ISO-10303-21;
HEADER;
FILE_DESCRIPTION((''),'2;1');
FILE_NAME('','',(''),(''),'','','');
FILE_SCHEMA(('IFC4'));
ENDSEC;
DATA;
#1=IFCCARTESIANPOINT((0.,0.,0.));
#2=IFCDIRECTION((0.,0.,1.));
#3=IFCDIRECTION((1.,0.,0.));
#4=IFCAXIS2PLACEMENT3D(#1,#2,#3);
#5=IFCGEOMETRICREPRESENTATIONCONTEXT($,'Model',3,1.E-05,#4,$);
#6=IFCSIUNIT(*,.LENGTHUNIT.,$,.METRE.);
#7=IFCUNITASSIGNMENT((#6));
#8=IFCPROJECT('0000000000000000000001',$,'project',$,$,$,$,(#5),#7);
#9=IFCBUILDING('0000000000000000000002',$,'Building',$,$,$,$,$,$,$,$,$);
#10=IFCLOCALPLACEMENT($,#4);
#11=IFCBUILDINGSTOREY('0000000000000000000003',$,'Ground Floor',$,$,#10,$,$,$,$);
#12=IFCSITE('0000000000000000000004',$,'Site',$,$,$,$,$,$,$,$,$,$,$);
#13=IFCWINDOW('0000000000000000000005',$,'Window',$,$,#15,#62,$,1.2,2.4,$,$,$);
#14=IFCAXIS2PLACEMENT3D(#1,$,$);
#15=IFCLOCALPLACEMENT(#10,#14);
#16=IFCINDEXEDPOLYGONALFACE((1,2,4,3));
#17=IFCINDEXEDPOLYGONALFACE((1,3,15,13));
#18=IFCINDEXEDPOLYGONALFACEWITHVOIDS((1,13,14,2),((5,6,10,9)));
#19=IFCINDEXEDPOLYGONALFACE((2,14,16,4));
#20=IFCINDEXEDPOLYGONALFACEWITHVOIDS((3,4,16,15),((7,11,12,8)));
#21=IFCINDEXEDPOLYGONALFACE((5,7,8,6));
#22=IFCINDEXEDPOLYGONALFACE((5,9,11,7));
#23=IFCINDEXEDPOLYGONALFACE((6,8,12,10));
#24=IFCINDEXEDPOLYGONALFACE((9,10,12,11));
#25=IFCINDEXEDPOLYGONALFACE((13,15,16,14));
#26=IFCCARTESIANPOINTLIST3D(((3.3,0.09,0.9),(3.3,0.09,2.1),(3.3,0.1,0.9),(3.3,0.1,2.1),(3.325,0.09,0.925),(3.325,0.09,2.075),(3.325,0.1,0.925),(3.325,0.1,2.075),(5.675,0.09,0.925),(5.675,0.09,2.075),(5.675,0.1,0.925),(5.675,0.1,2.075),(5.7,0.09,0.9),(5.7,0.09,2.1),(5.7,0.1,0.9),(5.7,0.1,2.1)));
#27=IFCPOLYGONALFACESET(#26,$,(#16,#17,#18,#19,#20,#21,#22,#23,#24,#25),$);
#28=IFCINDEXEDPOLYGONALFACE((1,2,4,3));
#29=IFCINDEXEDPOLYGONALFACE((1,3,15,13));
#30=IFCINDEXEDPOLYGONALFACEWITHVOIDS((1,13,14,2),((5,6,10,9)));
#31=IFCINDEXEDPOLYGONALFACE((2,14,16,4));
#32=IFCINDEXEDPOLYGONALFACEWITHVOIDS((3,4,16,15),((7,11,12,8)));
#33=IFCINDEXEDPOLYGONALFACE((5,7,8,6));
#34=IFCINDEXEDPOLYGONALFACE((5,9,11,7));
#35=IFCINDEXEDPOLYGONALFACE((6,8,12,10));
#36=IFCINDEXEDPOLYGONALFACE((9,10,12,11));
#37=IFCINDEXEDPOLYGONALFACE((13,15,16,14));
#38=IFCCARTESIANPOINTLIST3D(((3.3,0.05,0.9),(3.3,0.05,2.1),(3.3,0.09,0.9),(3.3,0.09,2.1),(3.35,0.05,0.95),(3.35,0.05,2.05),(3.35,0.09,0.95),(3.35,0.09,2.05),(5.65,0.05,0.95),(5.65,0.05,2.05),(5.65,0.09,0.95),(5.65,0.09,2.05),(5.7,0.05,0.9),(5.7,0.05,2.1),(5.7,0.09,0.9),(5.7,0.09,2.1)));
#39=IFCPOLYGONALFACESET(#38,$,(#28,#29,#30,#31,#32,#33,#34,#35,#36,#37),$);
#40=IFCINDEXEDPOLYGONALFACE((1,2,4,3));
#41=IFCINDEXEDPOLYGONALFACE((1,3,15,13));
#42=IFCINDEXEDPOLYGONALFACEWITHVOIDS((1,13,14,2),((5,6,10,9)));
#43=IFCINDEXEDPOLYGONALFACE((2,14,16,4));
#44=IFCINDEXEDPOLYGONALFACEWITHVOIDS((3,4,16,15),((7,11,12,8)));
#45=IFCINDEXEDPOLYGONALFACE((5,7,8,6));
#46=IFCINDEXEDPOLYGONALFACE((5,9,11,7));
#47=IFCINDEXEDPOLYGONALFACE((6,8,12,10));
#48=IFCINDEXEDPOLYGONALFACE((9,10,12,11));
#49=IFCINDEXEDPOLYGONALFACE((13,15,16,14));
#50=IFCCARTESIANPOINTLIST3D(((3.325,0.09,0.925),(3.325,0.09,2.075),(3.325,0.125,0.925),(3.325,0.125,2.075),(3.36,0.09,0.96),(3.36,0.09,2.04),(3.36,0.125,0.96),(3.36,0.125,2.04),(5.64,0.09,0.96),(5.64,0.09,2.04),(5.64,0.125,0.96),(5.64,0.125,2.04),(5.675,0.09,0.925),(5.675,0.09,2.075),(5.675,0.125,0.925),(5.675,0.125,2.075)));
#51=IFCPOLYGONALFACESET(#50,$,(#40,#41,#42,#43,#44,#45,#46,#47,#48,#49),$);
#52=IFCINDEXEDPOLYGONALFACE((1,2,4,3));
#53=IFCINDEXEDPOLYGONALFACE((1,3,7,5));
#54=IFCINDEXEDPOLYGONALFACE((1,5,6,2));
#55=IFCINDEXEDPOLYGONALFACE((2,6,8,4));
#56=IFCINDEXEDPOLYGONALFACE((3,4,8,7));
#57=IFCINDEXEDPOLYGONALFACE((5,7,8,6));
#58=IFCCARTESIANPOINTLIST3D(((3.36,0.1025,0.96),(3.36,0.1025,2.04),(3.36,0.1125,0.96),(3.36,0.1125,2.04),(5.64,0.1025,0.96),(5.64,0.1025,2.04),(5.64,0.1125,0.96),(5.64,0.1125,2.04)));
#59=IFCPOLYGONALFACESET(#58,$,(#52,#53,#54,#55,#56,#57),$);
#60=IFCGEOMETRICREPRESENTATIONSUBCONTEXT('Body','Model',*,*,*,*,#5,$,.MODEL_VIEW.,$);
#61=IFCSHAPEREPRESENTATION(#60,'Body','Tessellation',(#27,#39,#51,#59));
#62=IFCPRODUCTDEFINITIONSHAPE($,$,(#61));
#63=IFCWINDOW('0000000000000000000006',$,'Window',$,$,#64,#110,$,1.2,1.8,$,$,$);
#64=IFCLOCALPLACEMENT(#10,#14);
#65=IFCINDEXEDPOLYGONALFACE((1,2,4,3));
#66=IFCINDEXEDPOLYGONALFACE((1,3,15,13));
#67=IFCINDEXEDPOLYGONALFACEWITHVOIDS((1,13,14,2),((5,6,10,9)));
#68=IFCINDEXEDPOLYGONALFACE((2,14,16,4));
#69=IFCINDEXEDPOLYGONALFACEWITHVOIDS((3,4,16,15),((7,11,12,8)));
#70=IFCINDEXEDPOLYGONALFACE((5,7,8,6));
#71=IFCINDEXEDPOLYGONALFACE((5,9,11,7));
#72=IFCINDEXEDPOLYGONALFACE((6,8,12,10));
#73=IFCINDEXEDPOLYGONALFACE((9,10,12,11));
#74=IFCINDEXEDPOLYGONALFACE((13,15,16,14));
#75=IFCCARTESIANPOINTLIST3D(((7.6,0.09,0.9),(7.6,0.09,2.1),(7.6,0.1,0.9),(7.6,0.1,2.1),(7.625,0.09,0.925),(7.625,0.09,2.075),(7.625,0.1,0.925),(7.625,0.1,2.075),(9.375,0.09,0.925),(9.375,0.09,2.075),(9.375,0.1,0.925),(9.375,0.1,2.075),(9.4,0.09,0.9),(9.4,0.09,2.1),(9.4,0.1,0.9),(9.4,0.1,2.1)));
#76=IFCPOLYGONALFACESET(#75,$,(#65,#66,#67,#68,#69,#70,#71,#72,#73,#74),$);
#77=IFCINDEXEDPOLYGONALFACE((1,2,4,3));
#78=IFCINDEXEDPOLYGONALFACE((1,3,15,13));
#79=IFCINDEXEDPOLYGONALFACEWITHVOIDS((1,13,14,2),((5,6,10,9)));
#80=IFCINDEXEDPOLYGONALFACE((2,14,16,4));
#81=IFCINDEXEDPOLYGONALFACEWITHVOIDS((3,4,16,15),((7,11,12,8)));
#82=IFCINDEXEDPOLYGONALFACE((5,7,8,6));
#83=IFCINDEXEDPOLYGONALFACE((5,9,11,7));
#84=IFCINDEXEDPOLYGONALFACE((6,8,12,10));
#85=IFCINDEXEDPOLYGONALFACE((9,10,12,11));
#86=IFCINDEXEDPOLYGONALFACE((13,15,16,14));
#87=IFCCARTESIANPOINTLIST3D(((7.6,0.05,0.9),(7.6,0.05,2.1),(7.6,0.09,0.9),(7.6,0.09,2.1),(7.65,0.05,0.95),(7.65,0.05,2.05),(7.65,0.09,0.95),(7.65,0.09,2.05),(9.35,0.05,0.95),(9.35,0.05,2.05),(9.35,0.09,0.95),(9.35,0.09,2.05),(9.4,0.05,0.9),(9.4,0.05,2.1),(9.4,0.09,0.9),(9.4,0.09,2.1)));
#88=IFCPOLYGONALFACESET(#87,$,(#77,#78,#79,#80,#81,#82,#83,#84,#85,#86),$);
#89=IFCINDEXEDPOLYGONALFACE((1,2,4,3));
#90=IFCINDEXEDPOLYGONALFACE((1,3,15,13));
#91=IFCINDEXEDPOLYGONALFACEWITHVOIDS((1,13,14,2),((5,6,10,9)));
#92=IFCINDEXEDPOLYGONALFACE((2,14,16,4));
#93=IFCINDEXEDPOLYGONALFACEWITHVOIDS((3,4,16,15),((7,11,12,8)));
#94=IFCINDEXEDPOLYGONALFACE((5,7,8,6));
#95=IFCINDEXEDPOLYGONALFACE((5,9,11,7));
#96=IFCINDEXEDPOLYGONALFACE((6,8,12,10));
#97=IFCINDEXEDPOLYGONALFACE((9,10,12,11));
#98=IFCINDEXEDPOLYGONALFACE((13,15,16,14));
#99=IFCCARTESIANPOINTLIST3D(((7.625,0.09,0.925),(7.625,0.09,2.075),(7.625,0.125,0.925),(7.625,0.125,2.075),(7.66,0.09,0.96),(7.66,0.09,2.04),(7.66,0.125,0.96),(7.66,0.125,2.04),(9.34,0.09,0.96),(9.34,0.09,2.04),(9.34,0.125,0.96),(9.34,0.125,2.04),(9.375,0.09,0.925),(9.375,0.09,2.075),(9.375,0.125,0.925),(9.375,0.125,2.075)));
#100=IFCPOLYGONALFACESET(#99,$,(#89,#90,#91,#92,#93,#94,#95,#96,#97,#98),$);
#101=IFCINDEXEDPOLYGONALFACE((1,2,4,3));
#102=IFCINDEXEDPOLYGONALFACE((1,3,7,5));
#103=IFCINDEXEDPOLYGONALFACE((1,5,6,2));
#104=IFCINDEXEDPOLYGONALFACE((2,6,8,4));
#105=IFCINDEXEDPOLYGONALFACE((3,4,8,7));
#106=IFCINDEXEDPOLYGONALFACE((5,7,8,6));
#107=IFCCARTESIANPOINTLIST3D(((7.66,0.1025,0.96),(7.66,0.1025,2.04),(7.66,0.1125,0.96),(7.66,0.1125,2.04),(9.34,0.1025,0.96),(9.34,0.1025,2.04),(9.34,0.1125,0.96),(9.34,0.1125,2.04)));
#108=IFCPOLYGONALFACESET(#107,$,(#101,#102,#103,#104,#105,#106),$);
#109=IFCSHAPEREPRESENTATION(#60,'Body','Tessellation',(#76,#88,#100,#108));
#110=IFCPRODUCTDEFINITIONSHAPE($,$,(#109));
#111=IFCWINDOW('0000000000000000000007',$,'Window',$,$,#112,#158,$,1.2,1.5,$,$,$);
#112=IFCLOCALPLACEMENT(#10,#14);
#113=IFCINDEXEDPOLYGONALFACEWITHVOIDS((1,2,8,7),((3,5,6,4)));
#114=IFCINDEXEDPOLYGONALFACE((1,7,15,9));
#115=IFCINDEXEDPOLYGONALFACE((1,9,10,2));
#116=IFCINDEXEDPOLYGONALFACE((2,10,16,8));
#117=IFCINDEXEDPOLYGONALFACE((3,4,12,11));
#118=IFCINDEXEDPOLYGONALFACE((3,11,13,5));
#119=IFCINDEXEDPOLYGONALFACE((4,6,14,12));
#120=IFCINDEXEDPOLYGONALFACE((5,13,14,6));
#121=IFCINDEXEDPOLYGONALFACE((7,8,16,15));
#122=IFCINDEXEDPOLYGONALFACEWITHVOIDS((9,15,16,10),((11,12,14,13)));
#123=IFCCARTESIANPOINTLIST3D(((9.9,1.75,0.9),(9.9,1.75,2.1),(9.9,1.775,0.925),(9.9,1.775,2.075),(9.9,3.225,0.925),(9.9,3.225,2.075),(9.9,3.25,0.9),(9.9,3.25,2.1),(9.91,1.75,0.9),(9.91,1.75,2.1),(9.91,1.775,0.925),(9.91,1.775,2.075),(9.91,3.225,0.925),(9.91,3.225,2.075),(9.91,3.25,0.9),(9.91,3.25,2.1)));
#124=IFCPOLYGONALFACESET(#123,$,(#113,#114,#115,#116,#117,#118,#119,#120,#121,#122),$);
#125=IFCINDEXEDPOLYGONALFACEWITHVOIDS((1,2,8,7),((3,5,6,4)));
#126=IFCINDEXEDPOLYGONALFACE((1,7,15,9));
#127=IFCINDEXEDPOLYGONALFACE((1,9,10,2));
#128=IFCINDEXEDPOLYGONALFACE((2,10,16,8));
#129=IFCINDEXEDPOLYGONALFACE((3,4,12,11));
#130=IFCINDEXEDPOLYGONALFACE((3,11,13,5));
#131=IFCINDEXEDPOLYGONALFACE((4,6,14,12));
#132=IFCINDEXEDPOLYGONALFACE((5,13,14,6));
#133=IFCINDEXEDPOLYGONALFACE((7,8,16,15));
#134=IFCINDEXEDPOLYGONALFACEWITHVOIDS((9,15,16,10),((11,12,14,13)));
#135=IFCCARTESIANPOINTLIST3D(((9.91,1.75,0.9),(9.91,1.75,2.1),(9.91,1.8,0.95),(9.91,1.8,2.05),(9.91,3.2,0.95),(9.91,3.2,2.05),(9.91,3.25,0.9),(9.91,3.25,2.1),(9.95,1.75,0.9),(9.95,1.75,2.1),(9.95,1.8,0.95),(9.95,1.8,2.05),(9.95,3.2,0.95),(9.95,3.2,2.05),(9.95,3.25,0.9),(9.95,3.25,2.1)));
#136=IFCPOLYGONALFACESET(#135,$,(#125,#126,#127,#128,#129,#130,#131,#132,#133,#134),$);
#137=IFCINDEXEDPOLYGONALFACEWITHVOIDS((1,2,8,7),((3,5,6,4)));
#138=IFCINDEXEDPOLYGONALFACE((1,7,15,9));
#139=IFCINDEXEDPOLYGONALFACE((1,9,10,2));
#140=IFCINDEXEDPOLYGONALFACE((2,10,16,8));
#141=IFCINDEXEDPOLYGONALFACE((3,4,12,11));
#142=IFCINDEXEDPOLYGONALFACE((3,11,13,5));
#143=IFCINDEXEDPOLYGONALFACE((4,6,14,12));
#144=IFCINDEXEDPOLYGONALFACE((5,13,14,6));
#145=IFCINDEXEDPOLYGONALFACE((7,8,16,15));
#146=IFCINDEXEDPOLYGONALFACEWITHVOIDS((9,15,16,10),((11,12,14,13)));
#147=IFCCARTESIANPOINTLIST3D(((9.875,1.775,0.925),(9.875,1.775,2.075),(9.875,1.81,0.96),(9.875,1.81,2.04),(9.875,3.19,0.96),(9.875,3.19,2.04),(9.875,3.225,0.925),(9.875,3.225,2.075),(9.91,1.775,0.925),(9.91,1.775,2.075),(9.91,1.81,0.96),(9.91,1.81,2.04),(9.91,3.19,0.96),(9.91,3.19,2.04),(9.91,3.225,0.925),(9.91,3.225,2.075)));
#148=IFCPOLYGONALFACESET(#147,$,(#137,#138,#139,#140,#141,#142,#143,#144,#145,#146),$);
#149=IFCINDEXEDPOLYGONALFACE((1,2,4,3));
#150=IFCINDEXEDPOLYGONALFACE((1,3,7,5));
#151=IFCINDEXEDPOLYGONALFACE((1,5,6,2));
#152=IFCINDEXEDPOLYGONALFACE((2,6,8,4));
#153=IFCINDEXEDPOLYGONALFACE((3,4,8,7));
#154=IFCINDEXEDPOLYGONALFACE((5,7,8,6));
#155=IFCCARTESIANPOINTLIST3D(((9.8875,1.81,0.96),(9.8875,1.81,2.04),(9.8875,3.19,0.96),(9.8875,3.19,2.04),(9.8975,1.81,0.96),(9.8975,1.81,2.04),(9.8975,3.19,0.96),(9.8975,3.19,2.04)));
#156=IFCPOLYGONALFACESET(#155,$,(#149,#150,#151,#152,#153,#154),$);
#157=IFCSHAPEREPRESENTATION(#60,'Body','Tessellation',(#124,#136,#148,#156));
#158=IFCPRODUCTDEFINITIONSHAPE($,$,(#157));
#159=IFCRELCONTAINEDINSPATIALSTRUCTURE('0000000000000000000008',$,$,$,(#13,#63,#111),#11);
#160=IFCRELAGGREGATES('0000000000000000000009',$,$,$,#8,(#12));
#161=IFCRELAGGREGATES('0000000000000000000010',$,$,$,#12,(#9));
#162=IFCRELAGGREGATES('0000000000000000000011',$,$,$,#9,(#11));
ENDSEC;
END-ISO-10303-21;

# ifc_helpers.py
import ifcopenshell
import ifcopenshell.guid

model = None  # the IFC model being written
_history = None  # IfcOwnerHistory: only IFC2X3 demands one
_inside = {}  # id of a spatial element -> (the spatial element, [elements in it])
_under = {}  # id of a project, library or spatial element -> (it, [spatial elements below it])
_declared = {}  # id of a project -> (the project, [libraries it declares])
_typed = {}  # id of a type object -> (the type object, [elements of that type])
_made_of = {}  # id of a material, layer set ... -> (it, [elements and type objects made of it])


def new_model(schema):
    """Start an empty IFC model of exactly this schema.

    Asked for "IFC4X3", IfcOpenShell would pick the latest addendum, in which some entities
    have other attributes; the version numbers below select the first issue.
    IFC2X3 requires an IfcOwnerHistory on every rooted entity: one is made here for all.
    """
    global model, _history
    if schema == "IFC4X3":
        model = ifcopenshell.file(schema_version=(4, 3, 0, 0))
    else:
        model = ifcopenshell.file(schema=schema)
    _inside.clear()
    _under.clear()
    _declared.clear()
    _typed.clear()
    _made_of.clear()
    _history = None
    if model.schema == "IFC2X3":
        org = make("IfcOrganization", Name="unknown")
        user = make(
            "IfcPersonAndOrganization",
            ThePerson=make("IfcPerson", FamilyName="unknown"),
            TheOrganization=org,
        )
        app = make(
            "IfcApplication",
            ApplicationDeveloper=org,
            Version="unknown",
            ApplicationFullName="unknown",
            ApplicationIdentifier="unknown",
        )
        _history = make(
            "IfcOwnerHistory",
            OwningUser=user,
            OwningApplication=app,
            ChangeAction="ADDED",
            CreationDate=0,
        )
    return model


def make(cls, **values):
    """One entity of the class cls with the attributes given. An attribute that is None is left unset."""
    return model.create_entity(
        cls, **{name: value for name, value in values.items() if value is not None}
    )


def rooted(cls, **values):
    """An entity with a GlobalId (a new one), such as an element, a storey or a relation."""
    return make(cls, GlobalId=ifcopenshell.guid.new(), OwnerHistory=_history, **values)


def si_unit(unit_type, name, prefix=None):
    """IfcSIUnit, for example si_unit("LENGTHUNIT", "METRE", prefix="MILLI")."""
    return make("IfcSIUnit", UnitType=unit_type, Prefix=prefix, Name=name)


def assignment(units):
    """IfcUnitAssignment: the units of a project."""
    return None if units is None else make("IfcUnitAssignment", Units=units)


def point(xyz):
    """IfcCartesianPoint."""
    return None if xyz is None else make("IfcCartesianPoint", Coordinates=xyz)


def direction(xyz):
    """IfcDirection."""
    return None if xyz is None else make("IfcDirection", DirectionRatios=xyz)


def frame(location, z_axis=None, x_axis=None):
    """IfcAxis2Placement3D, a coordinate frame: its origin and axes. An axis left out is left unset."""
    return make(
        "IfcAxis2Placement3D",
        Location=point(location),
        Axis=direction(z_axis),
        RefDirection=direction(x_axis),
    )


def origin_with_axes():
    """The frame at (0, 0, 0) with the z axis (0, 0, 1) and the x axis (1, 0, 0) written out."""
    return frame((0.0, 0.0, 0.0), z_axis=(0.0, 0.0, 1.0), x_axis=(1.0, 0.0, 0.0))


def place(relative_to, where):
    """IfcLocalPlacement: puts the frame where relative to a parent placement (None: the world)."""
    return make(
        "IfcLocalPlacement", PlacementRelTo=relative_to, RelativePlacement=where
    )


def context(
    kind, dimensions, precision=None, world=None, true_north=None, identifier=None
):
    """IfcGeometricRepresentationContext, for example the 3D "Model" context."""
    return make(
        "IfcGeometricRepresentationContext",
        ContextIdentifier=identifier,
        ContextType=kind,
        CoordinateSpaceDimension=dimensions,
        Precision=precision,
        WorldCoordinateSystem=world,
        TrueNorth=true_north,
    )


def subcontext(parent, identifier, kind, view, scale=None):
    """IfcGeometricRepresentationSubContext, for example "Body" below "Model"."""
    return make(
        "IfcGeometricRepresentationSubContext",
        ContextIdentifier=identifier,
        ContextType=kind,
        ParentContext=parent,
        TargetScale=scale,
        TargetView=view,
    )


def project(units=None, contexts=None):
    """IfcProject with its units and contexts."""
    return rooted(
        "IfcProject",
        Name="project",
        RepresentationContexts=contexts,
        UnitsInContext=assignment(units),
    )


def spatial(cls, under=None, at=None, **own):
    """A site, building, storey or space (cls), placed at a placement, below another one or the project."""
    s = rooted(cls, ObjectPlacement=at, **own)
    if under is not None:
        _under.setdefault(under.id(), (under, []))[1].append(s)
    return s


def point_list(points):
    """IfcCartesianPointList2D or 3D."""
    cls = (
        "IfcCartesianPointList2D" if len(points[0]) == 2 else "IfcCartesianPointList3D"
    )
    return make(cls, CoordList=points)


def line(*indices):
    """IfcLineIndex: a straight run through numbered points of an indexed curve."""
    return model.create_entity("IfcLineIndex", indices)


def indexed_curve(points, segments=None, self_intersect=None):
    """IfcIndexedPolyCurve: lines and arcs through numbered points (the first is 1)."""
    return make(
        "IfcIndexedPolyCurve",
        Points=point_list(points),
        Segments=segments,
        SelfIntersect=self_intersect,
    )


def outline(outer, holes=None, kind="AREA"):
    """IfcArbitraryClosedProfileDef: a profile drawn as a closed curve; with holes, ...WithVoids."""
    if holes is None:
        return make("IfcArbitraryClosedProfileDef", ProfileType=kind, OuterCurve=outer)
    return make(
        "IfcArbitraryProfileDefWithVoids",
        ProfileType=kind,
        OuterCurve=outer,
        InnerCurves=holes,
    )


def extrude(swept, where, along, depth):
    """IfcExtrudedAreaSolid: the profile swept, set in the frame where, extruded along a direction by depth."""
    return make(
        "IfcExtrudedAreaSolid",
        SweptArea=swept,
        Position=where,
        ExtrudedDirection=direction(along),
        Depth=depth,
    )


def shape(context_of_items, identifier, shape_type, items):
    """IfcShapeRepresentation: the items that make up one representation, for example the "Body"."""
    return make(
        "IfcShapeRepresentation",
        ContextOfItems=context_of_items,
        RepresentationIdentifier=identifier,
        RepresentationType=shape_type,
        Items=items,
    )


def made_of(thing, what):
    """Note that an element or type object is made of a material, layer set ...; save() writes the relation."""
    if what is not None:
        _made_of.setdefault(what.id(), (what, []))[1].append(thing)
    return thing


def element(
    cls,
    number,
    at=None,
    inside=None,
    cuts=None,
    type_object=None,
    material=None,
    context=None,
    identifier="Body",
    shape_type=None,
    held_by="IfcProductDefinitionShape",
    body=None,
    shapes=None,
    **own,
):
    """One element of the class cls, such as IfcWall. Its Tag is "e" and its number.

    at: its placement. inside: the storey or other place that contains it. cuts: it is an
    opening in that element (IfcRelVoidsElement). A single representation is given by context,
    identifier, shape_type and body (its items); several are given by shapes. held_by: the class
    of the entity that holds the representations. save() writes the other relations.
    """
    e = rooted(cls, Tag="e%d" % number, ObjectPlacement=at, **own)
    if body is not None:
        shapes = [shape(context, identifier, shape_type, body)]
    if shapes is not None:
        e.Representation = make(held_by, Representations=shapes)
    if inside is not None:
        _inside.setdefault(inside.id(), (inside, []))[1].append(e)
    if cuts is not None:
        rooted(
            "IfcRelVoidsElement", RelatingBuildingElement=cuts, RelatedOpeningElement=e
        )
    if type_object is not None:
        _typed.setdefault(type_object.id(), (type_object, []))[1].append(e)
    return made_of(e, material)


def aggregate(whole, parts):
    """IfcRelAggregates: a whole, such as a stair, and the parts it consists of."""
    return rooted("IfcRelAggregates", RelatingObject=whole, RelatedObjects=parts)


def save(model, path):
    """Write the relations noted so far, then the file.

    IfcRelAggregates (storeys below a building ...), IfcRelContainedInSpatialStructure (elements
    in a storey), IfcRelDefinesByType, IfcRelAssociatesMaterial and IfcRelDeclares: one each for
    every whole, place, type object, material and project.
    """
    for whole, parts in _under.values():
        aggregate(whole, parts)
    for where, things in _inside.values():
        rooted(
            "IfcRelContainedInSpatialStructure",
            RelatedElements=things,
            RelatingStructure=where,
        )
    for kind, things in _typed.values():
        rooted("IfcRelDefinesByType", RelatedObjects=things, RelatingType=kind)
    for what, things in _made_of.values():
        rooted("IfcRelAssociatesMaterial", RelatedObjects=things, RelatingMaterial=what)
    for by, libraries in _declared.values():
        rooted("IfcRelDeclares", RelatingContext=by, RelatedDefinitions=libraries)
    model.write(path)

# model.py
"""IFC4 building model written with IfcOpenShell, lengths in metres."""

from ifc_helpers import new_model, si_unit, frame, origin_with_axes, place, context, subcontext, project, spatial, line, indexed_curve, outline, extrude, element, save


model = new_model("IFC4")

# Units and contexts
model_context = context("Model", 3, precision=1e-05, world=origin_with_axes())
body_context = subcontext(model_context, "Body", "Model", "MODEL_VIEW")
ifc_project = project(units=[si_unit("LENGTHUNIT", "METRE")], contexts=[model_context])

# Site, building, storey
site = spatial("IfcSite", under=ifc_project, Name="Site")
building = spatial("IfcBuilding", under=site, Name="Building")
storey_placement = place(None, origin_with_axes())
storey = spatial("IfcBuildingStorey", under=building, at=storey_placement, Name="Ground Floor")

# Windows
window_1_placement = place(storey_placement, frame((3.3, 0.0, 0.9), z_axis=(0.0, 0.0, 1.0), x_axis=(1.0, 0.0, 0.0)))
element("IfcWindow", 1, at=window_1_placement, inside=storey, Name="Window", OverallHeight=1.2, OverallWidth=2.4, context=body_context, shape_type="SweptSolid", body=[
    extrude(outline(indexed_curve([(0.0, 0.0), (2.4, 0.0), (2.4, 1.2), (0.0, 1.2)], segments=[line(1, 2, 3, 4, 1)]), holes=[indexed_curve([(0.025, 0.025), (2.375, 0.025), (2.375, 1.175), (0.025, 1.175)], segments=[line(1, 2, 3, 4, 1)])]), frame((0.0, 0.09, 0.0), z_axis=(0.0, -1.0, 0.0), x_axis=(1.0, 0.0, 0.0)), (0.0, 0.0, -1.0), 0.01),
    extrude(outline(indexed_curve([(0.0, 0.0), (2.4, 0.0), (2.4, 1.2), (0.0, 1.2)], segments=[line(1, 2, 3, 4, 1)]), holes=[indexed_curve([(0.05, 0.05), (2.35, 0.05), (2.35, 1.15), (0.05, 1.15)], segments=[line(1, 2, 3, 4, 1)])]), frame((0.0, 0.05, 0.0), z_axis=(0.0, -1.0, 0.0), x_axis=(1.0, 0.0, 0.0)), (0.0, 0.0, -1.0), 0.04),
    extrude(outline(indexed_curve([(0.0, 0.0), (2.35, 0.0), (2.35, 1.15), (0.0, 1.15)], segments=[line(1, 2, 3, 4, 1)]), holes=[indexed_curve([(0.035, 0.035), (2.315, 0.035), (2.315, 1.115), (0.035, 1.115)], segments=[line(1, 2, 3, 4, 1)])]), frame((0.025, 0.09, 0.025), z_axis=(0.0, -1.0, 0.0), x_axis=(1.0, 0.0, 0.0)), (0.0, 0.0, -1.0), 0.035),
    extrude(outline(indexed_curve([(0.035, 0.035), (2.315, 0.035), (2.315, 1.115), (0.035, 1.115)], segments=[line(1, 2, 3, 4, 1)])), frame((0.025, 0.1025, 0.025), z_axis=(0.0, -1.0, 0.0), x_axis=(1.0, 0.0, 0.0)), (0.0, 0.0, -1.0), 0.01),
])
window_2_placement = place(storey_placement, frame((7.6, 0.0, 0.9), z_axis=(0.0, 0.0, 1.0), x_axis=(1.0, 0.0, 0.0)))
element("IfcWindow", 2, at=window_2_placement, inside=storey, Name="Window", OverallHeight=1.2, OverallWidth=1.8, context=body_context, shape_type="SweptSolid", body=[
    extrude(outline(indexed_curve([(0.0, 0.0), (1.8, 0.0), (1.8, 1.2), (0.0, 1.2)], segments=[line(1, 2, 3, 4, 1)]), holes=[indexed_curve([(0.025, 0.025), (1.775, 0.025), (1.775, 1.175), (0.025, 1.175)], segments=[line(1, 2, 3, 4, 1)])]), frame((0.0, 0.09, 0.0), z_axis=(0.0, -1.0, 0.0), x_axis=(1.0, 0.0, 0.0)), (0.0, 0.0, -1.0), 0.01),
    extrude(outline(indexed_curve([(0.0, 0.0), (1.8, 0.0), (1.8, 1.2), (0.0, 1.2)], segments=[line(1, 2, 3, 4, 1)]), holes=[indexed_curve([(0.05, 0.05), (1.75, 0.05), (1.75, 1.15), (0.05, 1.15)], segments=[line(1, 2, 3, 4, 1)])]), frame((0.0, 0.05, 0.0), z_axis=(0.0, -1.0, 0.0), x_axis=(1.0, 0.0, 0.0)), (0.0, 0.0, -1.0), 0.04),
    extrude(outline(indexed_curve([(0.0, 0.0), (1.75, 0.0), (1.75, 1.15), (0.0, 1.15)], segments=[line(1, 2, 3, 4, 1)]), holes=[indexed_curve([(0.035, 0.035), (1.715, 0.035), (1.715, 1.115), (0.035, 1.115)], segments=[line(1, 2, 3, 4, 1)])]), frame((0.025, 0.09, 0.025), z_axis=(0.0, -1.0, 0.0), x_axis=(1.0, 0.0, 0.0)), (0.0, 0.0, -1.0), 0.035),
    extrude(outline(indexed_curve([(0.035, 0.035), (1.715, 0.035), (1.715, 1.115), (0.035, 1.115)], segments=[line(1, 2, 3, 4, 1)])), frame((0.025, 0.1025, 0.025), z_axis=(0.0, -1.0, 0.0), x_axis=(1.0, 0.0, 0.0)), (0.0, 0.0, -1.0), 0.01),
])
window_3_placement = place(storey_placement, frame((10.0, 1.75, 0.9), z_axis=(0.0, 0.0, 1.0), x_axis=(0.0, 1.0, 0.0)))
element("IfcWindow", 3, at=window_3_placement, inside=storey, Name="Window", OverallHeight=1.2, OverallWidth=1.5, context=body_context, shape_type="SweptSolid", body=[
    extrude(outline(indexed_curve([(0.0, 0.0), (1.5, 0.0), (1.5, 1.2), (0.0, 1.2)], segments=[line(1, 2, 3, 4, 1)]), holes=[indexed_curve([(0.025, 0.025), (1.475, 0.025), (1.475, 1.175), (0.025, 1.175)], segments=[line(1, 2, 3, 4, 1)])]), frame((0.0, 0.09, 0.0), z_axis=(0.0, -1.0, 0.0), x_axis=(1.0, 0.0, 0.0)), (0.0, 0.0, -1.0), 0.01),
    extrude(outline(indexed_curve([(0.0, 0.0), (1.5, 0.0), (1.5, 1.2), (0.0, 1.2)], segments=[line(1, 2, 3, 4, 1)]), holes=[indexed_curve([(0.05, 0.05), (1.45, 0.05), (1.45, 1.15), (0.05, 1.15)], segments=[line(1, 2, 3, 4, 1)])]), frame((0.0, 0.05, 0.0), z_axis=(0.0, -1.0, 0.0), x_axis=(1.0, 0.0, 0.0)), (0.0, 0.0, -1.0), 0.04),
    extrude(outline(indexed_curve([(0.0, 0.0), (1.45, 0.0), (1.45, 1.15), (0.0, 1.15)], segments=[line(1, 2, 3, 4, 1)]), holes=[indexed_curve([(0.035, 0.035), (1.415, 0.035), (1.415, 1.115), (0.035, 1.115)], segments=[line(1, 2, 3, 4, 1)])]), frame((0.025, 0.09, 0.025), z_axis=(0.0, -1.0, 0.0), x_axis=(1.0, 0.0, 0.0)), (0.0, 0.0, -1.0), 0.035),
    extrude(outline(indexed_curve([(0.035, 0.035), (1.415, 0.035), (1.415, 1.115), (0.035, 1.115)], segments=[line(1, 2, 3, 4, 1)])), frame((0.025, 0.1025, 0.025), z_axis=(0.0, -1.0, 0.0), x_axis=(1.0, 0.0, 0.0)), (0.0, 0.0, -1.0), 0.01),
])

save(model, "model.ifc")
